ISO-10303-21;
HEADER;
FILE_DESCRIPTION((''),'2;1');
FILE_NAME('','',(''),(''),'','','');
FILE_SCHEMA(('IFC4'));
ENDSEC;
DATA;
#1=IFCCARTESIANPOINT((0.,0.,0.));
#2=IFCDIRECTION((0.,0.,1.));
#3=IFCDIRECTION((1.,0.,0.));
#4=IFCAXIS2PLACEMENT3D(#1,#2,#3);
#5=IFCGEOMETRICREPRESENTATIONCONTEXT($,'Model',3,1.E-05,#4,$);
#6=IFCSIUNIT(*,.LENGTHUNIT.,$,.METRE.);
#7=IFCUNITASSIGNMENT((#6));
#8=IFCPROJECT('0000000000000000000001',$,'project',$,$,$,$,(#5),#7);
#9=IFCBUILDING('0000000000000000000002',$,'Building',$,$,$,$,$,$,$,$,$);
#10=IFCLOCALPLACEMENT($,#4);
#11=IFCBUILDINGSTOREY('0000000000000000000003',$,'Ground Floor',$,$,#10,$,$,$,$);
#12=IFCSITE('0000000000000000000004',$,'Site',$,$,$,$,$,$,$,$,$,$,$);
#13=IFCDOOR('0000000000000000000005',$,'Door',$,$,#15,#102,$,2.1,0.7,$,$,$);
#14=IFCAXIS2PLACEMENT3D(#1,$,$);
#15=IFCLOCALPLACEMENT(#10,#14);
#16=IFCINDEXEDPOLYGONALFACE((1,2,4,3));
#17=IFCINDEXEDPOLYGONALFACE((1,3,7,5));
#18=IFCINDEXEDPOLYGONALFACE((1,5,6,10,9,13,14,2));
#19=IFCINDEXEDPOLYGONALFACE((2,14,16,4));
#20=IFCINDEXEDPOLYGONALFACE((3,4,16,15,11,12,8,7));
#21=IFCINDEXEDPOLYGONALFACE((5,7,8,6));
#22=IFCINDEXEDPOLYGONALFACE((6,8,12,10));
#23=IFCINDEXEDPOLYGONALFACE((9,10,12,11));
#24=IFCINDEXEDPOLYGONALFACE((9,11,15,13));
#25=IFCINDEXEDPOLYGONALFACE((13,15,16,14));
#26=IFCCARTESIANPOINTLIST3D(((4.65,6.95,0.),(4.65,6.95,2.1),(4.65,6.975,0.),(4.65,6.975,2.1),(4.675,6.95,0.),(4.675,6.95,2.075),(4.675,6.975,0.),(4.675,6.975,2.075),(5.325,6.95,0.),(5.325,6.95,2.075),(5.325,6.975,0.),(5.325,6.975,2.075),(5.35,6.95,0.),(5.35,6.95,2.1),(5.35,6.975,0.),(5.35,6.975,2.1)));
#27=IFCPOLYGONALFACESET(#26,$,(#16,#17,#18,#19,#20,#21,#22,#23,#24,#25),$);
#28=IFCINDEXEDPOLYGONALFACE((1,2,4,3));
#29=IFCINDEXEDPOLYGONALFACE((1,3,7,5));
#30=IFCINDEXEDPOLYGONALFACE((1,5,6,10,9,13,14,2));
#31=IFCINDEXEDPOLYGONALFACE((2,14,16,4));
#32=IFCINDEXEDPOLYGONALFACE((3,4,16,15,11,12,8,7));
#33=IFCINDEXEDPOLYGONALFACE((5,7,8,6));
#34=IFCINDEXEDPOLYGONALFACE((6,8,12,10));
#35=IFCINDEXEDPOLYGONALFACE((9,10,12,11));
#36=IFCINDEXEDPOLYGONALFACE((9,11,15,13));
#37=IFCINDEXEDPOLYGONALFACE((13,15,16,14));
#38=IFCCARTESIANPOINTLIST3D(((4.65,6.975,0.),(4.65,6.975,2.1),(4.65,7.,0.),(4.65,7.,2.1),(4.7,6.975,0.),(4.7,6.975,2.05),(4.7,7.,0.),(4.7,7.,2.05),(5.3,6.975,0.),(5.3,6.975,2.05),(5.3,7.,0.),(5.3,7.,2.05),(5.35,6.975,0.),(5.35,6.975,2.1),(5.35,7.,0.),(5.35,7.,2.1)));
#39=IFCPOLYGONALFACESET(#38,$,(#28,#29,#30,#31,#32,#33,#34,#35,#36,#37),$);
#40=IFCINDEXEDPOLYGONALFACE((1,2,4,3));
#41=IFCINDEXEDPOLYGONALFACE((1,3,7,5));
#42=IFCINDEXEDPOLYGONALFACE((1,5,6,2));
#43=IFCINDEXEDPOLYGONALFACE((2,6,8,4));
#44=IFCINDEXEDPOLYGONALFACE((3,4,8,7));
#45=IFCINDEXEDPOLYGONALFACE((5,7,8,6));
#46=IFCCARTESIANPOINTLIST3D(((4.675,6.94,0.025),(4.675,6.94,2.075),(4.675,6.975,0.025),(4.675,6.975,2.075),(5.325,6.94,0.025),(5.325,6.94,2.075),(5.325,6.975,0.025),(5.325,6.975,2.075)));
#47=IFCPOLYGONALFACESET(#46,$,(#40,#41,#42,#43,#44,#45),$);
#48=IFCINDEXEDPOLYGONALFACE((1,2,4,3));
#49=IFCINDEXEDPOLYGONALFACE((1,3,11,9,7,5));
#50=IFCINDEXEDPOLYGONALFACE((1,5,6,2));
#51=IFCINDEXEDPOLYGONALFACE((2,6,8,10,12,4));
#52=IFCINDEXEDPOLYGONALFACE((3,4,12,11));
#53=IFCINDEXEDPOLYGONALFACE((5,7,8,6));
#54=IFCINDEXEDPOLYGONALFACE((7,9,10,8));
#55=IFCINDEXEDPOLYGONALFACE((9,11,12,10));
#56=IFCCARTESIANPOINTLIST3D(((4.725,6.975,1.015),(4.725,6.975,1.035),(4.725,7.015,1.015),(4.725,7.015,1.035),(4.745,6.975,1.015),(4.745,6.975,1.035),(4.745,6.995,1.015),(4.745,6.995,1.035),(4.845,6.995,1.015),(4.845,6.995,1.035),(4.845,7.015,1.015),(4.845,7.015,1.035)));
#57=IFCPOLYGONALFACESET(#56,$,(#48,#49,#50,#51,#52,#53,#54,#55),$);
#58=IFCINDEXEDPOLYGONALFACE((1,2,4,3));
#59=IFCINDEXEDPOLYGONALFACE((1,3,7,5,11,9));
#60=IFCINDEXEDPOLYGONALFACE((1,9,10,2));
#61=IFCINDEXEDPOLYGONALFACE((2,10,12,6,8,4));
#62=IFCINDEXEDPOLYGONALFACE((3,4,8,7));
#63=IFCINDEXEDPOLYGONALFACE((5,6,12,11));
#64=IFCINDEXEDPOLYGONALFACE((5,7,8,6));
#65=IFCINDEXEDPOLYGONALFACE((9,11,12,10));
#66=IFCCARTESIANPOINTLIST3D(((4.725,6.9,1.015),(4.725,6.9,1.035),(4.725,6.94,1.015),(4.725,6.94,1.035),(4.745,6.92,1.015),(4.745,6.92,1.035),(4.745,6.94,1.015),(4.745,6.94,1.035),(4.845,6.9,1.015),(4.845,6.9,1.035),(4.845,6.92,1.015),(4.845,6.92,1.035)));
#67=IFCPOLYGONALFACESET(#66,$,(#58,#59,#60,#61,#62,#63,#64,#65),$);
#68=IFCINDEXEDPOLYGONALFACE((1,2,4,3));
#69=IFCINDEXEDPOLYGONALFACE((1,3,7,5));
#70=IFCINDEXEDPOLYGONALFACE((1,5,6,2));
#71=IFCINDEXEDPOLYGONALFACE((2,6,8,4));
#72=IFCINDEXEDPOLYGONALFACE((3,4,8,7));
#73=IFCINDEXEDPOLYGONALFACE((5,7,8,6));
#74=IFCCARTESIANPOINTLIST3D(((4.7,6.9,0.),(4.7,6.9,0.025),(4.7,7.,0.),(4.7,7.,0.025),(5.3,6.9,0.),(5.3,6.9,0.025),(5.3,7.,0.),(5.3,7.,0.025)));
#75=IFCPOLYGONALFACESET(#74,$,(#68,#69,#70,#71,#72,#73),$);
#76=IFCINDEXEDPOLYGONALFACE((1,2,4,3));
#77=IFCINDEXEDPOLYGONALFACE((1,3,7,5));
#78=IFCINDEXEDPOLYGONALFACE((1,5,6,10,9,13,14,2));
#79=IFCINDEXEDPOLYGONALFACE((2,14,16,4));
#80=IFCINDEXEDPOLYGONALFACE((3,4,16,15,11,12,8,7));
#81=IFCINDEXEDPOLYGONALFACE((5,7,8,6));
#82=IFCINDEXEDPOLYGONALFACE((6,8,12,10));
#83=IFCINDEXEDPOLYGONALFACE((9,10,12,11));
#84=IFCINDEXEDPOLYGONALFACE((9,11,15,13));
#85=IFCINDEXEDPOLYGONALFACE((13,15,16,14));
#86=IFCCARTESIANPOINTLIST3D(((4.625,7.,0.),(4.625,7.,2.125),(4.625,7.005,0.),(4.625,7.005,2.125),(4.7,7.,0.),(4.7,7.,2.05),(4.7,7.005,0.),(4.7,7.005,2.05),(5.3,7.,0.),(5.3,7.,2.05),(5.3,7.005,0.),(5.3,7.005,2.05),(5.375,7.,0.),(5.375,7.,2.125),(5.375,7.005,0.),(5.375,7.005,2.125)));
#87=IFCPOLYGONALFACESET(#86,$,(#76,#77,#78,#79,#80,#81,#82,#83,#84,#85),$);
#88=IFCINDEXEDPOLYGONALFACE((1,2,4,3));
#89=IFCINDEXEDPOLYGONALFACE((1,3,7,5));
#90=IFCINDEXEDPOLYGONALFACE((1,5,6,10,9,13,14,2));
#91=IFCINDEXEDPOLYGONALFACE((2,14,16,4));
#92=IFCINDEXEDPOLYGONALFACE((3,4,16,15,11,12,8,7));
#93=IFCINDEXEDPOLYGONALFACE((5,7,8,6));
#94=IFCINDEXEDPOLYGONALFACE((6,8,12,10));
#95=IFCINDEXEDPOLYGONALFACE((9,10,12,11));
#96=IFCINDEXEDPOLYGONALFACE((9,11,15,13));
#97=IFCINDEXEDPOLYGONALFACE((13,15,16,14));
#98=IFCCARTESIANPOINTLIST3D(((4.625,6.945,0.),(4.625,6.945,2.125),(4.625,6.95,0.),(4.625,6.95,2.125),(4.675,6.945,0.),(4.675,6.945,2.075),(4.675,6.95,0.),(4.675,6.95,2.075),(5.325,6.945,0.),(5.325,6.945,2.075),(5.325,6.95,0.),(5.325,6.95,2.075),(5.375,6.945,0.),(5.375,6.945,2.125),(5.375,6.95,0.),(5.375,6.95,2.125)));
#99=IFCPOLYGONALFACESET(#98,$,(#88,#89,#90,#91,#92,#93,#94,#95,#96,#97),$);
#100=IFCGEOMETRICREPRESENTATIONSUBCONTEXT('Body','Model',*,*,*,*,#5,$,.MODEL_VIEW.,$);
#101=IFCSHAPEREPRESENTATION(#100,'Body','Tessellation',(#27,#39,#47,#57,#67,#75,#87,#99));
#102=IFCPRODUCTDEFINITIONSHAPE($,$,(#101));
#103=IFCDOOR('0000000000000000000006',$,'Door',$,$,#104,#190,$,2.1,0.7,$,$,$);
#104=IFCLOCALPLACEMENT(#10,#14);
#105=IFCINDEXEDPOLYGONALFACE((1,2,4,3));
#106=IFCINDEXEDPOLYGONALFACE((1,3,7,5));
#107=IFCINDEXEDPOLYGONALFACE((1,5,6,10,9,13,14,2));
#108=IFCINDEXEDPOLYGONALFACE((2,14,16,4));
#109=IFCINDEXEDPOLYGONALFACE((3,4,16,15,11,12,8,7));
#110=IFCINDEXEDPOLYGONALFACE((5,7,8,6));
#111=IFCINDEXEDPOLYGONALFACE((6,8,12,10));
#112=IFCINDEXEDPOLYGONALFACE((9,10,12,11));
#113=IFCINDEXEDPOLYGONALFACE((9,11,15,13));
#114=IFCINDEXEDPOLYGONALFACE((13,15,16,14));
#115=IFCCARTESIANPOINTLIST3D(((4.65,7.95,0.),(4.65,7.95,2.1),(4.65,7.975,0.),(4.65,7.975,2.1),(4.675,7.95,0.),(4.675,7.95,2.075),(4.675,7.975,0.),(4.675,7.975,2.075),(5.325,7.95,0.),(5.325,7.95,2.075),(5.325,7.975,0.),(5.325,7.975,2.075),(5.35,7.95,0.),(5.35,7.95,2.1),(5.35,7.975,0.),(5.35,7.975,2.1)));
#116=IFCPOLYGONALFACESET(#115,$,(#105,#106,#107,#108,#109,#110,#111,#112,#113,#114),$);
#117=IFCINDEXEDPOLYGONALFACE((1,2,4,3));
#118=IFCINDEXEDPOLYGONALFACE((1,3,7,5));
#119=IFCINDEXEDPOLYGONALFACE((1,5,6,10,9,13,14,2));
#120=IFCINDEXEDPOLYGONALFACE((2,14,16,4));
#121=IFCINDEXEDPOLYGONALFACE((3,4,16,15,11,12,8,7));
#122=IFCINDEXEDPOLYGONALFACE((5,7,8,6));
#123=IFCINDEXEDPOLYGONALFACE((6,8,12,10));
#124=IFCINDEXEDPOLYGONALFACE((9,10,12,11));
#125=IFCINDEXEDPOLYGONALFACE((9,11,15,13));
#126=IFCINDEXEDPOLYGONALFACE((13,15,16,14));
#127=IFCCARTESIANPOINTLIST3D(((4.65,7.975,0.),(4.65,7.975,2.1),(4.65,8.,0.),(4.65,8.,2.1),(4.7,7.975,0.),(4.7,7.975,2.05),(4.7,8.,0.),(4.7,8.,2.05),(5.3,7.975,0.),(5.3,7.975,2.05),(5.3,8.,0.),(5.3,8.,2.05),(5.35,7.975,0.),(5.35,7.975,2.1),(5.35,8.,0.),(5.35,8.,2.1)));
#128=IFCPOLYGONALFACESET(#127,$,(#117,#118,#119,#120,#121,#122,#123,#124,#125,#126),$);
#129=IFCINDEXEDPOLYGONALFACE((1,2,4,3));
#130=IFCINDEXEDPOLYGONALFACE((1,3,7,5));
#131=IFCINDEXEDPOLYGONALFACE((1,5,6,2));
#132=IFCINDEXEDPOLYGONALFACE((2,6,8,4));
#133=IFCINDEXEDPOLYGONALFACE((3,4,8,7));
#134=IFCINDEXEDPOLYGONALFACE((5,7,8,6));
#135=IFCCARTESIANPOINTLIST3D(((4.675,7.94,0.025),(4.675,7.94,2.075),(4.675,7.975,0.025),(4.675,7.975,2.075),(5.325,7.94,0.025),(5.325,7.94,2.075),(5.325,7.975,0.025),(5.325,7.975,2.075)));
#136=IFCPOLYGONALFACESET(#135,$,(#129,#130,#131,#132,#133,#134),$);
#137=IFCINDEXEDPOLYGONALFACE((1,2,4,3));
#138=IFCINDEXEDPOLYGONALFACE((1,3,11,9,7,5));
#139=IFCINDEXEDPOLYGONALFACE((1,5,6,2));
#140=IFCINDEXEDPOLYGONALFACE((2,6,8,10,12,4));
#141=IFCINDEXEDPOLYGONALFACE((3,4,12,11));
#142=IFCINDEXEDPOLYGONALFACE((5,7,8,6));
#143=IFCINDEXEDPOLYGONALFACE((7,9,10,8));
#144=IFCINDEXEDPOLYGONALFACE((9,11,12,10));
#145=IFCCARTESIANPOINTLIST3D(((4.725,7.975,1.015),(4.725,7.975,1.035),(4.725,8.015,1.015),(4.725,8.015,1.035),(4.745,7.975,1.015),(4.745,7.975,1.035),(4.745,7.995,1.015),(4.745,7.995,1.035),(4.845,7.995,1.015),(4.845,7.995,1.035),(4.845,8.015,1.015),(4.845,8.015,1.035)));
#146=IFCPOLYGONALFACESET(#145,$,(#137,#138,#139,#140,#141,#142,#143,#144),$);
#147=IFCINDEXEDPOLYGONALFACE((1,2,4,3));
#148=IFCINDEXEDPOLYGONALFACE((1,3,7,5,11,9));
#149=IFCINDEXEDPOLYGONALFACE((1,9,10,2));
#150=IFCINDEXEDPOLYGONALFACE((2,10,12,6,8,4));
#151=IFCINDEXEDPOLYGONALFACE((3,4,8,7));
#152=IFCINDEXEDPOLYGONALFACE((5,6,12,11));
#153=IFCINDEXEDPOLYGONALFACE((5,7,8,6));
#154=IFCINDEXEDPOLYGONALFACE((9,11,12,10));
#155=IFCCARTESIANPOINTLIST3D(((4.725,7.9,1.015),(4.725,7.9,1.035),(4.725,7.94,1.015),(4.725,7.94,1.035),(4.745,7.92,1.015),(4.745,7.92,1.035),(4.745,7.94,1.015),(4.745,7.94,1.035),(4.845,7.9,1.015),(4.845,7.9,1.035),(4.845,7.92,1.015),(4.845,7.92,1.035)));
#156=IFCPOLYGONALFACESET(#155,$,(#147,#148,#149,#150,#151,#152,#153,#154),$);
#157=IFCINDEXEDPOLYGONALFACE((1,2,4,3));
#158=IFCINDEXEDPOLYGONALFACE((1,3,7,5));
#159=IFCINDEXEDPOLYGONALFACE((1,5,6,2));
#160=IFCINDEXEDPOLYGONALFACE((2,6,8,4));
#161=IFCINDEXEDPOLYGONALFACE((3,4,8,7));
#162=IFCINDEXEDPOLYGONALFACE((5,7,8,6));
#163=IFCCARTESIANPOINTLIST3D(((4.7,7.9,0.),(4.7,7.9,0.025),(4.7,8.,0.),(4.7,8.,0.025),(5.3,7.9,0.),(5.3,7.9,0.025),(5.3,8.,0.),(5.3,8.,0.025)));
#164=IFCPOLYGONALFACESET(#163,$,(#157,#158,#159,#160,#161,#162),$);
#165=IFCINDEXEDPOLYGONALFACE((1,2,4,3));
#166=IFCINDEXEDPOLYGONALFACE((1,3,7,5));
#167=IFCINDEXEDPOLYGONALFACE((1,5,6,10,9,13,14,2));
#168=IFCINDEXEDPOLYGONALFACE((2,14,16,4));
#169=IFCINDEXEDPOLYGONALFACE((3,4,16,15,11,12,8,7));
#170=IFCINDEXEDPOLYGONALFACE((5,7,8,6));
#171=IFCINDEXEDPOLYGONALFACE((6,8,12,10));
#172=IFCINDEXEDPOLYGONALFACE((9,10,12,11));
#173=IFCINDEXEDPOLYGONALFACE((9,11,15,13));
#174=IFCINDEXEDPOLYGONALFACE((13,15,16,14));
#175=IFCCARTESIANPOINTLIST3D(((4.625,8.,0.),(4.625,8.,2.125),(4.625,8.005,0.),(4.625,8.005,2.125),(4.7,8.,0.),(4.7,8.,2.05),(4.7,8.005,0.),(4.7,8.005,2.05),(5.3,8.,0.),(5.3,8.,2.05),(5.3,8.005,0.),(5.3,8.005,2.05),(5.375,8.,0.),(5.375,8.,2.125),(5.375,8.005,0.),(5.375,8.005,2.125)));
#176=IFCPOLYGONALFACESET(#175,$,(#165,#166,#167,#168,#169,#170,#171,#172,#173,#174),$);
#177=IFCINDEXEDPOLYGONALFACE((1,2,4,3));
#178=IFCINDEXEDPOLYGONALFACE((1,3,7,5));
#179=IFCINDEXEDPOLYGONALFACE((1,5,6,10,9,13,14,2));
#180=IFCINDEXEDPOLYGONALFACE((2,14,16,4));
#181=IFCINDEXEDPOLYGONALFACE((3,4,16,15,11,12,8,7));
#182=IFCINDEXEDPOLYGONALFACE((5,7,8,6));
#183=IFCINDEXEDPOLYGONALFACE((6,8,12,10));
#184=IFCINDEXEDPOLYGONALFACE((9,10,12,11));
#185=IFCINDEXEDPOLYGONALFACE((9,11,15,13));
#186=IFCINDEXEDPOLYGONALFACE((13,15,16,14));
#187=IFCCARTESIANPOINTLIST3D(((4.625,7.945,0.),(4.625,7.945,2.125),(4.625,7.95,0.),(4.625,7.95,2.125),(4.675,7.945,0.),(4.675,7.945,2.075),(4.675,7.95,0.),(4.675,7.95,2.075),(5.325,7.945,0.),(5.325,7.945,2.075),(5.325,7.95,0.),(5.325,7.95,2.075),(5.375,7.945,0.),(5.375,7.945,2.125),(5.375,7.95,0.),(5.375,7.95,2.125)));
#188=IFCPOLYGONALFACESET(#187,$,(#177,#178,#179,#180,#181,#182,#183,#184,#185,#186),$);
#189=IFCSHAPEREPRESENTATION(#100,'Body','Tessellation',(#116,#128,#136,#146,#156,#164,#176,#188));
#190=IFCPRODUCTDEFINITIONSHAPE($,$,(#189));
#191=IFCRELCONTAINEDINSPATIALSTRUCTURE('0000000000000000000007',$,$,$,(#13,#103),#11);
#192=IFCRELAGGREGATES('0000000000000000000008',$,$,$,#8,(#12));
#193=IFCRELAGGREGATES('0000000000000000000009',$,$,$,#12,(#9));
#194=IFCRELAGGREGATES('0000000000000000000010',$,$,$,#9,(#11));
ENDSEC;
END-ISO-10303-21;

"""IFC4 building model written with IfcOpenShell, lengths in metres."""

from ifc_helpers import new_model, si_unit, frame, origin_with_axes, place, context, subcontext, project, spatial, line, indexed_curve, outline, extrude, element, save


model = new_model("IFC4")

# Units and contexts
model_context = context("Model", 3, precision=1e-05, world=origin_with_axes())
body_context = subcontext(model_context, "Body", "Model", "MODEL_VIEW")
ifc_project = project(units=[si_unit("LENGTHUNIT", "METRE")], contexts=[model_context])

# Site, building, storey
site = spatial("IfcSite", under=ifc_project, Name="Site")
building = spatial("IfcBuilding", under=site, Name="Building")
storey_placement = place(None, origin_with_axes())
storey = spatial("IfcBuildingStorey", under=building, at=storey_placement, Name="Ground Floor")

# Doors
door_1_placement = place(storey_placement, frame((5.35, 7.0, 0.0), z_axis=(0.0, 0.0, 1.0), x_axis=(-1.0, 0.0, 0.0)))
element("IfcDoor", 1, at=door_1_placement, inside=storey, Name="Door", OverallHeight=2.1, OverallWidth=0.7, context=body_context, shape_type="SweptSolid", body=[
    extrude(outline(indexed_curve([(0.0, 0.0), (0.0, 2.1), (0.7, 2.1), (0.7, 0.0), (0.675, 0.0), (0.675, 2.075), (0.025, 2.075), (0.025, 0.0)], segments=[line(1, 2, 3, 4, 5, 6, 7, 8, 1)])), frame((0.0, 0.025, 0.0), z_axis=(0.0, -1.0, 0.0), x_axis=(1.0, 0.0, 0.0)), (0.0, 0.0, -1.0), 0.025),
    extrude(outline(indexed_curve([(0.0, 0.0), (0.0, 2.1), (0.7, 2.1), (0.7, 0.0), (0.65, 0.0), (0.65, 2.05), (0.05, 2.05), (0.05, 0.0)], segments=[line(1, 2, 3, 4, 5, 6, 7, 8, 1)])), frame((0.0, 0.0, 0.0), z_axis=(0.0, -1.0, 0.0), x_axis=(1.0, 0.0, 0.0)), (0.0, 0.0, -1.0), 0.025),
    extrude(outline(indexed_curve([(0.0, 0.0), (0.65, 0.0), (0.65, 0.035), (0.0, 0.035)], segments=[line(1, 2, 3, 4, 1)])), frame((0.025, 0.025, 0.025), z_axis=(0.0, 0.0, 1.0), x_axis=(1.0, 0.0, 0.0)), (0.0, 0.0, 1.0), 2.05),
    extrude(outline(indexed_curve([(0.0, 0.0), (0.0, -0.04), (-0.12, -0.04), (-0.12, -0.02), (-0.02, -0.02), (-0.02, 0.0)], segments=[line(1, 2, 3, 4, 5, 6, 1)])), frame((0.625, 0.025, 1.015), z_axis=(0.0, 0.0, 1.0), x_axis=(1.0, 0.0, 0.0)), (0.0, 0.0, 1.0), 0.02),
    extrude(outline(indexed_curve([(0.0, 0.0), (0.0, 0.04), (-0.12, 0.04), (-0.12, 0.02), (-0.02, 0.02), (-0.02, 0.0)], segments=[line(1, 2, 3, 4, 5, 6, 1)])), frame((0.625, 0.06, 1.015), z_axis=(0.0, 0.0, 1.0), x_axis=(1.0, 0.0, 0.0)), (0.0, 0.0, 1.0), 0.02),
    extrude(outline(indexed_curve([(0.0, 0.0), (0.6, 0.0), (0.6, 0.1), (0.0, 0.1)], segments=[line(1, 2, 3, 4, 1)])), frame((0.05, 0.0, 0.0), z_axis=(0.0, 0.0, 1.0), x_axis=(1.0, 0.0, 0.0)), (0.0, 0.0, 1.0), 0.025),
    extrude(outline(indexed_curve([(0.0, 0.0), (0.0, 2.125), (0.75, 2.125), (0.75, 0.0), (0.675, 0.0), (0.675, 2.05), (0.075, 2.05), (0.075, 0.0)], segments=[line(1, 2, 3, 4, 5, 6, 7, 8, 1)])), frame((-0.025, -0.005, 0.0), z_axis=(0.0, -1.0, 0.0), x_axis=(1.0, 0.0, 0.0)), (0.0, 0.0, -1.0), 0.005),
    extrude(outline(indexed_curve([(0.0, 0.0), (0.0, 2.125), (0.75, 2.125), (0.75, 0.0), (0.7, 0.0), (0.7, 2.075), (0.05, 2.075), (0.05, 0.0)], segments=[line(1, 2, 3, 4, 5, 6, 7, 8, 1)])), frame((-0.025, 0.05, 0.0), z_axis=(0.0, -1.0, 0.0), x_axis=(1.0, 0.0, 0.0)), (0.0, 0.0, -1.0), 0.005),
])
door_2_placement = place(storey_placement, frame((5.35, 8.0, 0.0), z_axis=(0.0, 0.0, 1.0), x_axis=(-1.0, 0.0, 0.0)))
element("IfcDoor", 2, at=door_2_placement, inside=storey, Name="Door", OverallHeight=2.1, OverallWidth=0.7, context=body_context, shape_type="SweptSolid", body=[
    extrude(outline(indexed_curve([(0.0, 0.0), (0.0, 2.1), (0.7, 2.1), (0.7, 0.0), (0.675, 0.0), (0.675, 2.075), (0.025, 2.075), (0.025, 0.0)], segments=[line(1, 2, 3, 4, 5, 6, 7, 8, 1)])), frame((0.0, 0.025, 0.0), z_axis=(0.0, -1.0, 0.0), x_axis=(1.0, 0.0, 0.0)), (0.0, 0.0, -1.0), 0.025),
    extrude(outline(indexed_curve([(0.0, 0.0), (0.0, 2.1), (0.7, 2.1), (0.7, 0.0), (0.65, 0.0), (0.65, 2.05), (0.05, 2.05), (0.05, 0.0)], segments=[line(1, 2, 3, 4, 5, 6, 7, 8, 1)])), frame((0.0, 0.0, 0.0), z_axis=(0.0, -1.0, 0.0), x_axis=(1.0, 0.0, 0.0)), (0.0, 0.0, -1.0), 0.025),
    extrude(outline(indexed_curve([(0.0, 0.0), (0.65, 0.0), (0.65, 0.035), (0.0, 0.035)], segments=[line(1, 2, 3, 4, 1)])), frame((0.025, 0.025, 0.025), z_axis=(0.0, 0.0, 1.0), x_axis=(1.0, 0.0, 0.0)), (0.0, 0.0, 1.0), 2.05),
    extrude(outline(indexed_curve([(0.0, 0.0), (0.0, -0.04), (-0.12, -0.04), (-0.12, -0.02), (-0.02, -0.02), (-0.02, 0.0)], segments=[line(1, 2, 3, 4, 5, 6, 1)])), frame((0.625, 0.025, 1.015), z_axis=(0.0, 0.0, 1.0), x_axis=(1.0, 0.0, 0.0)), (0.0, 0.0, 1.0), 0.02),
    extrude(outline(indexed_curve([(0.0, 0.0), (0.0, 0.04), (-0.12, 0.04), (-0.12, 0.02), (-0.02, 0.02), (-0.02, 0.0)], segments=[line(1, 2, 3, 4, 5, 6, 1)])), frame((0.625, 0.06, 1.015), z_axis=(0.0, 0.0, 1.0), x_axis=(1.0, 0.0, 0.0)), (0.0, 0.0, 1.0), 0.02),
    extrude(outline(indexed_curve([(0.0, 0.0), (0.6, 0.0), (0.6, 0.1), (0.0, 0.1)], segments=[line(1, 2, 3, 4, 1)])), frame((0.05, 0.0, 0.0), z_axis=(0.0, 0.0, 1.0), x_axis=(1.0, 0.0, 0.0)), (0.0, 0.0, 1.0), 0.025),
    extrude(outline(indexed_curve([(0.0, 0.0), (0.0, 2.125), (0.75, 2.125), (0.75, 0.0), (0.675, 0.0), (0.675, 2.05), (0.075, 2.05), (0.075, 0.0)], segments=[line(1, 2, 3, 4, 5, 6, 7, 8, 1)])), frame((-0.025, -0.005, 0.0), z_axis=(0.0, -1.0, 0.0), x_axis=(1.0, 0.0, 0.0)), (0.0, 0.0, -1.0), 0.005),
    extrude(outline(indexed_curve([(0.0, 0.0), (0.0, 2.125), (0.75, 2.125), (0.75, 0.0), (0.7, 0.0), (0.7, 2.075), (0.05, 2.075), (0.05, 0.0)], segments=[line(1, 2, 3, 4, 5, 6, 7, 8, 1)])), frame((-0.025, 0.05, 0.0), z_axis=(0.0, -1.0, 0.0), x_axis=(1.0, 0.0, 0.0)), (0.0, 0.0, -1.0), 0.005),
])

save(model, "model.ifc")
